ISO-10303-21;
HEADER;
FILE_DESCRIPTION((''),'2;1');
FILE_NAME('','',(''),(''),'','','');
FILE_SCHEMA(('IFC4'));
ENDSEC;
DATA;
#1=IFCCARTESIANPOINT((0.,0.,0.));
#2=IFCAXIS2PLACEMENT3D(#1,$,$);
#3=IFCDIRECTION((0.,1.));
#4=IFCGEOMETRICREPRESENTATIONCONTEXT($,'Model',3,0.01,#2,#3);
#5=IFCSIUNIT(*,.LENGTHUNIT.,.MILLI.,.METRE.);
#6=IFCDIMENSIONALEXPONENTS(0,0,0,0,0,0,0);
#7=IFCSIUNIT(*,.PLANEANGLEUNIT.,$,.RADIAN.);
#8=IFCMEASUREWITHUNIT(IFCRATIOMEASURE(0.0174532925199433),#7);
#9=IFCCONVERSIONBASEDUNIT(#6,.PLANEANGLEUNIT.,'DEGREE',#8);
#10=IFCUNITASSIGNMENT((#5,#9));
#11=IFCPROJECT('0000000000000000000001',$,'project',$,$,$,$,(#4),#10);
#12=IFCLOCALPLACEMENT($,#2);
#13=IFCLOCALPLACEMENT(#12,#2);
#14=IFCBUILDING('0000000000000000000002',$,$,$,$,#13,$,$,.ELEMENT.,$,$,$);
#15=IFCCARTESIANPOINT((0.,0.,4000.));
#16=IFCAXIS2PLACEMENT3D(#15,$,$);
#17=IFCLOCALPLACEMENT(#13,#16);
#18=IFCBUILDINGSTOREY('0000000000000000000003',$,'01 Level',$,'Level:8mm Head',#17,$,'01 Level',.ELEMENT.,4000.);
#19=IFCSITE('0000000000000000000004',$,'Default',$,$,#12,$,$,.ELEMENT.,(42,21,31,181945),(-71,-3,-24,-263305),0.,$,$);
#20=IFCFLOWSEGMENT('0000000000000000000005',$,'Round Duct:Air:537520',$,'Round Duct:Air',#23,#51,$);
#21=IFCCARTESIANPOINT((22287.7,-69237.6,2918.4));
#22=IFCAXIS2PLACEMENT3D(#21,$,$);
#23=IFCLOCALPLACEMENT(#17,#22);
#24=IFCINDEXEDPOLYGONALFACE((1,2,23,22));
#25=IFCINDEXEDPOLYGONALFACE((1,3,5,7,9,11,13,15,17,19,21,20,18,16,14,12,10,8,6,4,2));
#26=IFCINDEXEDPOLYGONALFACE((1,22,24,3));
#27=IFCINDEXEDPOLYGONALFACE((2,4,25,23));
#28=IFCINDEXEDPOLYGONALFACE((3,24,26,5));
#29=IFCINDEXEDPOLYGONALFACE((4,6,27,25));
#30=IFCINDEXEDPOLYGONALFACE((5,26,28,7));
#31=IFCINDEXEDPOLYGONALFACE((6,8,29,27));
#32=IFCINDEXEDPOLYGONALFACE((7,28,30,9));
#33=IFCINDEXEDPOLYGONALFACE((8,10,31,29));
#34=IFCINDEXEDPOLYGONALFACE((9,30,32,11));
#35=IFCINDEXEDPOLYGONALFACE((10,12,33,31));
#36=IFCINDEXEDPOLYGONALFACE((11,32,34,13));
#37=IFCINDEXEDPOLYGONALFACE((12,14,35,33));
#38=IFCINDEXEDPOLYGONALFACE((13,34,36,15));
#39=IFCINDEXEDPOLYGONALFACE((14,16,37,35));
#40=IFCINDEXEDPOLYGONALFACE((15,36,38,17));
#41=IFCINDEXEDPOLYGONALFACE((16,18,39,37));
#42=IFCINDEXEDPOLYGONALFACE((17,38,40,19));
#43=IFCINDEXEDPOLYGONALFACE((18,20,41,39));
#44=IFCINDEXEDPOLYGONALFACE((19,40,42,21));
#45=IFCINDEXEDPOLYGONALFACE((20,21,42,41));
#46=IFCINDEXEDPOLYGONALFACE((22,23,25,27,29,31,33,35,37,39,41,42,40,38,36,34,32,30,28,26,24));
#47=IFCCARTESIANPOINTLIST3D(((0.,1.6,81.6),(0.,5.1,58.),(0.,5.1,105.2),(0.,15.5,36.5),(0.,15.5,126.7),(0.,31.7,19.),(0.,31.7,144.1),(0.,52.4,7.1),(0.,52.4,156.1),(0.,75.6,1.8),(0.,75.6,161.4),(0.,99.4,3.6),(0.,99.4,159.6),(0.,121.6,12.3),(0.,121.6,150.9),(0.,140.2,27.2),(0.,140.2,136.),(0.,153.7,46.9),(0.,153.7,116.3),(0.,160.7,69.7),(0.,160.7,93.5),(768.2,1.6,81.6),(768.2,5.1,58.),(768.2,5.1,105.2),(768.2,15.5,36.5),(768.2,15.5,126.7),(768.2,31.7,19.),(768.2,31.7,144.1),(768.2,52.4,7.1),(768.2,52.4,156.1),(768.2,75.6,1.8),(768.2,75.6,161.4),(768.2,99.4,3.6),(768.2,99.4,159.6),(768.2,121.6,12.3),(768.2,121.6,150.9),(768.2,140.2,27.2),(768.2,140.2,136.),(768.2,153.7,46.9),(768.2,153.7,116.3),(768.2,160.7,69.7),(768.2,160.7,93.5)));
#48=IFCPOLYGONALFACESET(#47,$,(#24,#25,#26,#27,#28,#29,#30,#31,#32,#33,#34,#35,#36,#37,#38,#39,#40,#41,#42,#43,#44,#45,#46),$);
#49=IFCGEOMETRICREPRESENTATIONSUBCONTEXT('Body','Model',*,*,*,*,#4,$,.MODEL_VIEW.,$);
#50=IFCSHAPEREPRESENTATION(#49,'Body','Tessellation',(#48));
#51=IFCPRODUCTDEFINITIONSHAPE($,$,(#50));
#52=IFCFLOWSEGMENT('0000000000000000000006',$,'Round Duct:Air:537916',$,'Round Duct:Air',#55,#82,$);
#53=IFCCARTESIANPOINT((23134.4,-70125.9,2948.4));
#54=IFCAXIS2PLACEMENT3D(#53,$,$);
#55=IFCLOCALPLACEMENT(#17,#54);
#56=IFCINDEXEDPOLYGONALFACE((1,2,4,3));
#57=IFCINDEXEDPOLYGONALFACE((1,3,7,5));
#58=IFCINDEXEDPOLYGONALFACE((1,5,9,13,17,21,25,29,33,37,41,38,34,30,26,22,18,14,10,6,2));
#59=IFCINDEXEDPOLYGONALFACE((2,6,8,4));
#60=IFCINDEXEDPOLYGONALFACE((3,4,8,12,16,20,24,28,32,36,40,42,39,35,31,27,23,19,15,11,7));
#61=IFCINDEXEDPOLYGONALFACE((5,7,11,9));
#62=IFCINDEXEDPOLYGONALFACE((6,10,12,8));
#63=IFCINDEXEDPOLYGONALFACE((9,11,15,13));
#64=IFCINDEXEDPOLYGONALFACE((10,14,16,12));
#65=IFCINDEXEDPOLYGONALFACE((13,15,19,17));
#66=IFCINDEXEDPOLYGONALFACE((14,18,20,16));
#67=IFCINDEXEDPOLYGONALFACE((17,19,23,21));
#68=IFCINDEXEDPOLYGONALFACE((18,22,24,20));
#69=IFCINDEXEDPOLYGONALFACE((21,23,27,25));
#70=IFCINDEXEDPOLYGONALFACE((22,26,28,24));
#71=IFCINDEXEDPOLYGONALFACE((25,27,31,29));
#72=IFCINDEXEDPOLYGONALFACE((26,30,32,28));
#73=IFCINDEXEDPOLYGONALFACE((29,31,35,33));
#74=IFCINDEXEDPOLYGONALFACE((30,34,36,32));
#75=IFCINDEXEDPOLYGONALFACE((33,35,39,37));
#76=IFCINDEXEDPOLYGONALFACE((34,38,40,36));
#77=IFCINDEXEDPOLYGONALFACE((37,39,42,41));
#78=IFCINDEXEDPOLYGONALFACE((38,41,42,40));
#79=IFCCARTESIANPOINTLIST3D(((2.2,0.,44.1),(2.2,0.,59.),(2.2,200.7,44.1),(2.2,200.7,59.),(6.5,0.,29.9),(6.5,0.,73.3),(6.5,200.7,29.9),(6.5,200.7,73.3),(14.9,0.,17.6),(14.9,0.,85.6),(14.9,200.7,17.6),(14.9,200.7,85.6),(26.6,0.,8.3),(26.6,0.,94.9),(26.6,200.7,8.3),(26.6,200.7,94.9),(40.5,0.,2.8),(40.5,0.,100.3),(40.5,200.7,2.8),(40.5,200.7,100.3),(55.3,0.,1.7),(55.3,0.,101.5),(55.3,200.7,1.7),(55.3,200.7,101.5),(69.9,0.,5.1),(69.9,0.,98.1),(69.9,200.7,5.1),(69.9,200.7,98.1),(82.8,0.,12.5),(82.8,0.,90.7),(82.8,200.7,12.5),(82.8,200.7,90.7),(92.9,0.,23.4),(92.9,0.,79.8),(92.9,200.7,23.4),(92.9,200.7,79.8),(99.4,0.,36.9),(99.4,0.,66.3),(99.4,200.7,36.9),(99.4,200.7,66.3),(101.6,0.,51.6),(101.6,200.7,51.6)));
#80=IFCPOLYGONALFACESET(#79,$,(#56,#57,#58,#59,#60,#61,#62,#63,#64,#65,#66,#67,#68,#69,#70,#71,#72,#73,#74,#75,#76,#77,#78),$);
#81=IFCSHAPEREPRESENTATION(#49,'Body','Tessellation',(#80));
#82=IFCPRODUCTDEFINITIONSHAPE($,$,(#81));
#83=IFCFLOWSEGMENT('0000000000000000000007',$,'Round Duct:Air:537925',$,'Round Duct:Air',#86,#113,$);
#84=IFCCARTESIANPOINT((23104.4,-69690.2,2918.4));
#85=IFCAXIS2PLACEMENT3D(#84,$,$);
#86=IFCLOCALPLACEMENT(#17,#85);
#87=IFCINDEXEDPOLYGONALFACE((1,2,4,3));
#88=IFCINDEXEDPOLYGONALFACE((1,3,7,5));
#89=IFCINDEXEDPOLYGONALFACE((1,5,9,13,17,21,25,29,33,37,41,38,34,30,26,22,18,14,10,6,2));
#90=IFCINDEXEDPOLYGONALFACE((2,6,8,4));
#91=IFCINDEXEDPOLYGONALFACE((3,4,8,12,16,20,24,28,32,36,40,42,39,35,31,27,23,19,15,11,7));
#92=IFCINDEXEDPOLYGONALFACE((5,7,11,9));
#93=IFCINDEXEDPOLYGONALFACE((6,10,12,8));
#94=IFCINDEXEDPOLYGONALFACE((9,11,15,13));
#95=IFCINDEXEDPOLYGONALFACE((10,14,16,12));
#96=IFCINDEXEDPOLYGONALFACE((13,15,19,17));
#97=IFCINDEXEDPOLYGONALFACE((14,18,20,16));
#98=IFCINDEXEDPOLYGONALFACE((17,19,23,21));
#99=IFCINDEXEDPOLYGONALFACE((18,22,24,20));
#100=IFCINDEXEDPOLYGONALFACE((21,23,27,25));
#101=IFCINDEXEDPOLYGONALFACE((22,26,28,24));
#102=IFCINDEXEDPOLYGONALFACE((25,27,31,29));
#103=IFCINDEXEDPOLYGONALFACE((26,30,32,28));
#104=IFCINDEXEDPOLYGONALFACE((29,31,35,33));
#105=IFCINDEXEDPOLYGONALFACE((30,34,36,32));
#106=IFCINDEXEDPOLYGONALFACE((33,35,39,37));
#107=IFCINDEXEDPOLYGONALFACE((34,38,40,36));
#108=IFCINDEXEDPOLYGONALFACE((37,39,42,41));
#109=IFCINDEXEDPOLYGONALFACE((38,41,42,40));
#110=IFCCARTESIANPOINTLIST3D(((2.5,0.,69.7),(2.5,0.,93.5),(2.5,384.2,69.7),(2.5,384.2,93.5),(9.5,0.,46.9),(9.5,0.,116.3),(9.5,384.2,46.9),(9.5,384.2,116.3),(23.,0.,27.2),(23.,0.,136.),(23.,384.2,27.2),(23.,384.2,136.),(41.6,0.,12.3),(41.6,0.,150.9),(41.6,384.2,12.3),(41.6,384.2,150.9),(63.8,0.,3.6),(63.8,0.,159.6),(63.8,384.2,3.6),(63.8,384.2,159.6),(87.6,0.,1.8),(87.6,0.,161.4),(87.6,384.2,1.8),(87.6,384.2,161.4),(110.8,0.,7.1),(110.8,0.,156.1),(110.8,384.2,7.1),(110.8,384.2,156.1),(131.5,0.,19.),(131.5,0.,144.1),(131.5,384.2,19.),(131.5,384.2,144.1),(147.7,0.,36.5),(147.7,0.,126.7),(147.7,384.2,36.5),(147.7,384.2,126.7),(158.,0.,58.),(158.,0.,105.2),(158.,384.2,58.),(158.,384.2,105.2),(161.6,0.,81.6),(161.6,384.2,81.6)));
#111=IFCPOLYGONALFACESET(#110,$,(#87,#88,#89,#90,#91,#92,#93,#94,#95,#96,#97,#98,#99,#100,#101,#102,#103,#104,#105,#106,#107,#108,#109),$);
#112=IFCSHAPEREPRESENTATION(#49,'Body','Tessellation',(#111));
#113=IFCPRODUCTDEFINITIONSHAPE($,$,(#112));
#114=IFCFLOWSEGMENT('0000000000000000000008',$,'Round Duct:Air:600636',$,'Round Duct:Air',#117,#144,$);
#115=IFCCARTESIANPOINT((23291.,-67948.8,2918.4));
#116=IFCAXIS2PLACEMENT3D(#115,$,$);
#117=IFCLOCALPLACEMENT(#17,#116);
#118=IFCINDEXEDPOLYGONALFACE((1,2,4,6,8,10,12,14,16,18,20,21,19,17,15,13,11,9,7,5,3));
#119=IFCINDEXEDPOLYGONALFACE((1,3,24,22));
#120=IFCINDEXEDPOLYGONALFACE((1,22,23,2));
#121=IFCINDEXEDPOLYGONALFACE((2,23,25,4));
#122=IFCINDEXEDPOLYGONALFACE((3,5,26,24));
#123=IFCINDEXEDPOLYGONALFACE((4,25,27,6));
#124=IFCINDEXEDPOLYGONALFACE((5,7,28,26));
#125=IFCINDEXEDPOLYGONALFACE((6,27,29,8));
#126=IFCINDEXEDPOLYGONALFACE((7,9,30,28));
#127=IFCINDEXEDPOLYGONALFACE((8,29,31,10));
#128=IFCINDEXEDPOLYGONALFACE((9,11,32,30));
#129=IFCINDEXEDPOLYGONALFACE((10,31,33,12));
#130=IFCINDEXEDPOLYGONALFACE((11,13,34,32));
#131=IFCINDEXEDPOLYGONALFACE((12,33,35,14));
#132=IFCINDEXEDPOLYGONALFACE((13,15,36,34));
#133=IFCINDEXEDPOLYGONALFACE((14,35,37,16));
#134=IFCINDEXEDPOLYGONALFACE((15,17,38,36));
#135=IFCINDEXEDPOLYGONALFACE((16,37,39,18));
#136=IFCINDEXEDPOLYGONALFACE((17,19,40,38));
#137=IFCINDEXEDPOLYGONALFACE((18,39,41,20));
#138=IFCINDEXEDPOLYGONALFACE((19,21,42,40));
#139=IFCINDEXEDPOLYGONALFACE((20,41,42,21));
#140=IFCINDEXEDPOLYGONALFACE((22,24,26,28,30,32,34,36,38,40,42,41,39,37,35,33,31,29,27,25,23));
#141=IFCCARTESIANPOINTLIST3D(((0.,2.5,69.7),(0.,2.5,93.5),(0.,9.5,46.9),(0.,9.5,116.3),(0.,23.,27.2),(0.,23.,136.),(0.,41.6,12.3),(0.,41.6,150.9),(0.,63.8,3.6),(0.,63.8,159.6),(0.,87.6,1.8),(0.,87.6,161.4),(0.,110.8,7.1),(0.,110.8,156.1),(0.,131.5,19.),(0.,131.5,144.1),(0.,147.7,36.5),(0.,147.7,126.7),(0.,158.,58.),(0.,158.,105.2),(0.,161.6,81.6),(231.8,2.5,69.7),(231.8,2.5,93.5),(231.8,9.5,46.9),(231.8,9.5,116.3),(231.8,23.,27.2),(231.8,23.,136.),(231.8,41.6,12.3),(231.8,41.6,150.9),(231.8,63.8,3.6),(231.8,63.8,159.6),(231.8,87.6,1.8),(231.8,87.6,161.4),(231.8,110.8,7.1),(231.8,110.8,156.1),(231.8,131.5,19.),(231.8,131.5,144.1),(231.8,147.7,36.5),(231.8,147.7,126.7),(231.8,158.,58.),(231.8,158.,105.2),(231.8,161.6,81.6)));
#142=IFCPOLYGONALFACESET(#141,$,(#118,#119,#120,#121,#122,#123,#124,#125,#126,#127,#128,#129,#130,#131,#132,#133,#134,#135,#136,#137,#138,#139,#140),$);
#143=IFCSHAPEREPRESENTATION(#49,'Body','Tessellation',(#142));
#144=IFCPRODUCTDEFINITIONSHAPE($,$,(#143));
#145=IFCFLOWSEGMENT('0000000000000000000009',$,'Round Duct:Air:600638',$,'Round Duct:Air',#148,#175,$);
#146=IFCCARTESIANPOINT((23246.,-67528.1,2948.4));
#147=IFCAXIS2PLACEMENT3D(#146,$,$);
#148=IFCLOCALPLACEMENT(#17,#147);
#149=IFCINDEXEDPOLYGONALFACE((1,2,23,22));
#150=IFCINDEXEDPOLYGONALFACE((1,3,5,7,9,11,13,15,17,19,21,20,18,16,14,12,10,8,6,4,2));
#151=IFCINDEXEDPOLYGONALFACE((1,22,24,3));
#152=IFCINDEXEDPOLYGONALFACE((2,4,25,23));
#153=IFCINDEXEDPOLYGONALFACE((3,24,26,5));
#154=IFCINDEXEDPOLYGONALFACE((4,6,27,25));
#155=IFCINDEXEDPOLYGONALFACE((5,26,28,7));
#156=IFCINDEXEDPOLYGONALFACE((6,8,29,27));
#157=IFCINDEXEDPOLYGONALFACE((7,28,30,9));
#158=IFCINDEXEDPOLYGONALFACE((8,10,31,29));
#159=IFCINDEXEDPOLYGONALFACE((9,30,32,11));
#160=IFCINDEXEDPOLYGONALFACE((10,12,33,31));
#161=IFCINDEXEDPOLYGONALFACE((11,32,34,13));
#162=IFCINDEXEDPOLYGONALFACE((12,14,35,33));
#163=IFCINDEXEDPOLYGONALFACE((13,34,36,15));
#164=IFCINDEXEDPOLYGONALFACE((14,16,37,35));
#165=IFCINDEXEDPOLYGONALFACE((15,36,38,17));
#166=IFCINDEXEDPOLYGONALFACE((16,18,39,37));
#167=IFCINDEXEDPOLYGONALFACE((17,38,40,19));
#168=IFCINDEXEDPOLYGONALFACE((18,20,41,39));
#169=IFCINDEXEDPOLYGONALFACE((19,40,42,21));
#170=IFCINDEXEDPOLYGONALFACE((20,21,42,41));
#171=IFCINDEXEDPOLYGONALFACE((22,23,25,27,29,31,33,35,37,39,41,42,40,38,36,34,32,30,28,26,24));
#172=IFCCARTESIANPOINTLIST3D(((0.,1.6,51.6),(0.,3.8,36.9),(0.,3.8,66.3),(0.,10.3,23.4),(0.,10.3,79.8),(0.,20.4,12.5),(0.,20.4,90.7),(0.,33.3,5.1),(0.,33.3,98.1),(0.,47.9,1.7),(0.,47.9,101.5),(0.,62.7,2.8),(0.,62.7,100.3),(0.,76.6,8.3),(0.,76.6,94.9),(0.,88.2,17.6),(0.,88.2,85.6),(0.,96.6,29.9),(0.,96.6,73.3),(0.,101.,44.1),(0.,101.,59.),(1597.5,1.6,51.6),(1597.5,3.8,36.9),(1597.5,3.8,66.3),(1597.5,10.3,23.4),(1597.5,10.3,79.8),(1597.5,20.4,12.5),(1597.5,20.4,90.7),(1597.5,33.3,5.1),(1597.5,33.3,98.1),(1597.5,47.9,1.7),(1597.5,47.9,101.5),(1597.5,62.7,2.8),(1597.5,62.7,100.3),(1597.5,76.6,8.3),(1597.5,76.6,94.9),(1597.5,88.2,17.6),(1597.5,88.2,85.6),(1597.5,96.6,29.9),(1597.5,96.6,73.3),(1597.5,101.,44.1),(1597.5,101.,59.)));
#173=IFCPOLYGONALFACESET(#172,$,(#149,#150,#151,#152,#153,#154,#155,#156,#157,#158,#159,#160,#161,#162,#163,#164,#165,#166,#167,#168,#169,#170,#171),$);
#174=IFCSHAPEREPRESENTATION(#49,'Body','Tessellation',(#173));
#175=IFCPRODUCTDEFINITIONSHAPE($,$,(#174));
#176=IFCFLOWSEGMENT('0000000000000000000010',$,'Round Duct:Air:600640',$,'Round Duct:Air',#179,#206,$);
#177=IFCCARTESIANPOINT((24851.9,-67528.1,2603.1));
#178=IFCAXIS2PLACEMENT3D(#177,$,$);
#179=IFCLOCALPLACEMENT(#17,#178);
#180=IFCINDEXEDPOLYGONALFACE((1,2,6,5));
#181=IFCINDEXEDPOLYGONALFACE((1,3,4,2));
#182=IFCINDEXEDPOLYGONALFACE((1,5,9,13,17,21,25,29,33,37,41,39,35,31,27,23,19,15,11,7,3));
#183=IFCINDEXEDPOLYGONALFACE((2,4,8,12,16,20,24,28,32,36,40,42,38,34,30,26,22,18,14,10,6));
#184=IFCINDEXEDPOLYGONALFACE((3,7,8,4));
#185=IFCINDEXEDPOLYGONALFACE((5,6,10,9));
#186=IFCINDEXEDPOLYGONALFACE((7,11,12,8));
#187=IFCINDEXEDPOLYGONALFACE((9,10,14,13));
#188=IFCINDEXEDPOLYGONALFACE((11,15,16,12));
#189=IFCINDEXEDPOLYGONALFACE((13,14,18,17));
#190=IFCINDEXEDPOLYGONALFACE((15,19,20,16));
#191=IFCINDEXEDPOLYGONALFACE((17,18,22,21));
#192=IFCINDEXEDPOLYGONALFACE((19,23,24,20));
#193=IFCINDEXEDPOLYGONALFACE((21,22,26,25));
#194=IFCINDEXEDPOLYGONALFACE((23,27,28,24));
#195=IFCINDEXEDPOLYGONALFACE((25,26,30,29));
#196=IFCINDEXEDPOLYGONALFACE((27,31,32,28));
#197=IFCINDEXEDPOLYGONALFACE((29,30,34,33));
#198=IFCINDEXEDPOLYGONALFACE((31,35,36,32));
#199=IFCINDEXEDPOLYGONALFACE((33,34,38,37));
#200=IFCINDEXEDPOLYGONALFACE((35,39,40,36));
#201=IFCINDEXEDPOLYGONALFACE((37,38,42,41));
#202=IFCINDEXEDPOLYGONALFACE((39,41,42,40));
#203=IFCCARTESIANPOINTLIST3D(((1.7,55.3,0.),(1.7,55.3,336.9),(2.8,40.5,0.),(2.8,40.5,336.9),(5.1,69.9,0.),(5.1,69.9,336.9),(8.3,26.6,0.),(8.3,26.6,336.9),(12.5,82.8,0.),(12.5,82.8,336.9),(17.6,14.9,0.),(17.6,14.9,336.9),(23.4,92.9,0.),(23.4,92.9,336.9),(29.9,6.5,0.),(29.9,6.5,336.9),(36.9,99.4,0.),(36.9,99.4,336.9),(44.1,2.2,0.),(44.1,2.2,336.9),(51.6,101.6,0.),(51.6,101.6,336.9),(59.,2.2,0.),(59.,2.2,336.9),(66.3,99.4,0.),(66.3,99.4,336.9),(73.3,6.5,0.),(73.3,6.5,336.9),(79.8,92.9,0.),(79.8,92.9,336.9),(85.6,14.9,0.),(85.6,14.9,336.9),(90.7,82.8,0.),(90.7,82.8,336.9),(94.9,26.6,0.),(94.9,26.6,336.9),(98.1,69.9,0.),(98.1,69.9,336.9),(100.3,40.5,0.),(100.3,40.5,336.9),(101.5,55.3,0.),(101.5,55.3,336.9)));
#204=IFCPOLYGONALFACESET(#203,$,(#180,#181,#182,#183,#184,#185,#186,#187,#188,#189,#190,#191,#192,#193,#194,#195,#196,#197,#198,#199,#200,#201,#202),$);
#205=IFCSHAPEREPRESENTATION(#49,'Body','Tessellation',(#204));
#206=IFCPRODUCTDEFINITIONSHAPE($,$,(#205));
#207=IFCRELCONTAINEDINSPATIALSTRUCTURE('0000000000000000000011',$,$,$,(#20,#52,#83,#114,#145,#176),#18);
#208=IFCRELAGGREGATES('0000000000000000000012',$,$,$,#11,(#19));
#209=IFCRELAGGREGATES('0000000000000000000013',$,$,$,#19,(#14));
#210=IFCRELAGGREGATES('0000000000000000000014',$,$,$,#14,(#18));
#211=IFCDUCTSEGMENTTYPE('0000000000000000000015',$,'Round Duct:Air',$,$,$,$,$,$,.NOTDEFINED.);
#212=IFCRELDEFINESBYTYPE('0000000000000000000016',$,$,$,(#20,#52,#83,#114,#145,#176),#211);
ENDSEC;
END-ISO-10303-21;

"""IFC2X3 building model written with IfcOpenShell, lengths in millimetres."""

from ifc_helpers import new_model, entity, si_unit, converted_unit, direction, frame, frame_2d, origin, origin_2d_with_axis, place, context, subcontext, project, spatial, circle, extrude, type_object, element, save


model = new_model("IFC2X3")

# Units and contexts
model_context = context("Model", 3, precision=0.01, world=origin(), true_north=direction((0.0, 1.0)))
body_context = subcontext(model_context, "Body", "Model", "MODEL_VIEW")
ifc_project = project(units=[si_unit("LENGTHUNIT", "METRE", prefix="MILLI"), converted_unit("PLANEANGLEUNIT", "DEGREE", entity("IfcRatioMeasure", 0.0174532925199433), si_unit("PLANEANGLEUNIT", "RADIAN"), dimensions=[0, 0, 0, 0, 0, 0, 0])], contexts=[model_context])

# Site, building, storey
site_placement = place(None, origin())
site = spatial("IfcSite", under=ifc_project, at=site_placement, Name="Default", CompositionType="ELEMENT", RefLatitude=(42, 21, 31, 181945), RefLongitude=(-71, -3, -24, -263305), RefElevation=0.0)
building_placement = place(site_placement, origin())
building = spatial("IfcBuilding", under=site, at=building_placement, CompositionType="ELEMENT")
storey_placement = place(building_placement, frame((0.0, 0.0, 4000.0)))
storey = spatial("IfcBuildingStorey", under=building, at=storey_placement, Name="01 Level", ObjectType="Level:8mm Head", LongName="01 Level", CompositionType="ELEMENT", Elevation=4000.0)

# Flow segments
duct_segment_type_1 = type_object("IfcDuctSegmentType", Name="Round Duct:Air", PredefinedType="NOTDEFINED")
flow_segment_1_placement = place(storey_placement, frame((22287.7, -69237.6, 2918.4)))
element("IfcFlowSegment", 1, at=flow_segment_1_placement, inside=storey, type_object=duct_segment_type_1, Name="Round Duct:Air:537520", ObjectType="Round Duct:Air", context=body_context, shape_type="SweptSolid", body=[
    extrude(circle(Radius=80.0, at=origin_2d_with_axis()), frame((0.0, 81.6, 81.6), z_axis=(1.0, 0.0, 0.0), x_axis=(0.0, -1.0, 0.0)), (0.0, 0.0, 1.0), 768.2),
])
flow_segment_2_placement = place(storey_placement, frame((23134.4, -70125.9, 2948.4)))
element("IfcFlowSegment", 2, at=flow_segment_2_placement, inside=storey, type_object=duct_segment_type_1, Name="Round Duct:Air:537916", ObjectType="Round Duct:Air", context=body_context, shape_type="SweptSolid", body=[
    extrude(circle(Radius=50.0, at=frame_2d((0.0, 0.0), x_axis=(1.0, 0.0))), frame((51.6, 0.0, 51.6), z_axis=(0.0, 1.0, 0.0), x_axis=(1.0, 0.0, 0.0)), (0.0, 0.0, 1.0), 200.7),
])
flow_segment_3_placement = place(storey_placement, frame((23104.4, -69690.2, 2918.4)))
element("IfcFlowSegment", 3, at=flow_segment_3_placement, inside=storey, type_object=duct_segment_type_1, Name="Round Duct:Air:537925", ObjectType="Round Duct:Air", context=body_context, shape_type="SweptSolid", body=[
    extrude(circle(Radius=80.0, at=origin_2d_with_axis()), frame((81.6, 0.0, 81.6), z_axis=(0.0, 1.0, 0.0), x_axis=(1.0, 0.0, 0.0)), (0.0, 0.0, 1.0), 384.2),
])
flow_segment_4_placement = place(storey_placement, frame((23291.0, -67948.8, 2918.4)))
element("IfcFlowSegment", 4, at=flow_segment_4_placement, inside=storey, type_object=duct_segment_type_1, Name="Round Duct:Air:600636", ObjectType="Round Duct:Air", context=body_context, shape_type="SweptSolid", body=[
    extrude(circle(Radius=80.0, at=frame_2d((0.0, 0.0), x_axis=(1.0, 0.0))), frame((0.0, 81.6, 81.6), z_axis=(1.0, 0.0, 0.0), x_axis=(0.0, 1.0, 0.0)), (0.0, 0.0, 1.0), 231.8),
])
flow_segment_5_placement = place(storey_placement, frame((23246.0, -67528.1, 2948.4)))
element("IfcFlowSegment", 5, at=flow_segment_5_placement, inside=storey, type_object=duct_segment_type_1, Name="Round Duct:Air:600638", ObjectType="Round Duct:Air", context=body_context, shape_type="SweptSolid", body=[
    extrude(circle(Radius=50.0, at=origin_2d_with_axis()), frame((0.0, 51.6, 51.6), z_axis=(1.0, 0.0, 0.0), x_axis=(0.0, -1.0, 0.0)), (0.0, 0.0, 1.0), 1597.5),
])
flow_segment_6_placement = place(storey_placement, frame((24851.9, -67528.1, 2603.1)))
element("IfcFlowSegment", 6, at=flow_segment_6_placement, inside=storey, type_object=duct_segment_type_1, Name="Round Duct:Air:600640", ObjectType="Round Duct:Air", context=body_context, shape_type="SweptSolid", body=[
    extrude(circle(Radius=50.0, at=origin_2d_with_axis()), frame((51.6, 51.6, 0.0), z_axis=(0.0, 0.0, 1.0), x_axis=(0.0, 1.0, 0.0)), (0.0, 0.0, 1.0), 336.9),
])

save(model, "model.ifc")
